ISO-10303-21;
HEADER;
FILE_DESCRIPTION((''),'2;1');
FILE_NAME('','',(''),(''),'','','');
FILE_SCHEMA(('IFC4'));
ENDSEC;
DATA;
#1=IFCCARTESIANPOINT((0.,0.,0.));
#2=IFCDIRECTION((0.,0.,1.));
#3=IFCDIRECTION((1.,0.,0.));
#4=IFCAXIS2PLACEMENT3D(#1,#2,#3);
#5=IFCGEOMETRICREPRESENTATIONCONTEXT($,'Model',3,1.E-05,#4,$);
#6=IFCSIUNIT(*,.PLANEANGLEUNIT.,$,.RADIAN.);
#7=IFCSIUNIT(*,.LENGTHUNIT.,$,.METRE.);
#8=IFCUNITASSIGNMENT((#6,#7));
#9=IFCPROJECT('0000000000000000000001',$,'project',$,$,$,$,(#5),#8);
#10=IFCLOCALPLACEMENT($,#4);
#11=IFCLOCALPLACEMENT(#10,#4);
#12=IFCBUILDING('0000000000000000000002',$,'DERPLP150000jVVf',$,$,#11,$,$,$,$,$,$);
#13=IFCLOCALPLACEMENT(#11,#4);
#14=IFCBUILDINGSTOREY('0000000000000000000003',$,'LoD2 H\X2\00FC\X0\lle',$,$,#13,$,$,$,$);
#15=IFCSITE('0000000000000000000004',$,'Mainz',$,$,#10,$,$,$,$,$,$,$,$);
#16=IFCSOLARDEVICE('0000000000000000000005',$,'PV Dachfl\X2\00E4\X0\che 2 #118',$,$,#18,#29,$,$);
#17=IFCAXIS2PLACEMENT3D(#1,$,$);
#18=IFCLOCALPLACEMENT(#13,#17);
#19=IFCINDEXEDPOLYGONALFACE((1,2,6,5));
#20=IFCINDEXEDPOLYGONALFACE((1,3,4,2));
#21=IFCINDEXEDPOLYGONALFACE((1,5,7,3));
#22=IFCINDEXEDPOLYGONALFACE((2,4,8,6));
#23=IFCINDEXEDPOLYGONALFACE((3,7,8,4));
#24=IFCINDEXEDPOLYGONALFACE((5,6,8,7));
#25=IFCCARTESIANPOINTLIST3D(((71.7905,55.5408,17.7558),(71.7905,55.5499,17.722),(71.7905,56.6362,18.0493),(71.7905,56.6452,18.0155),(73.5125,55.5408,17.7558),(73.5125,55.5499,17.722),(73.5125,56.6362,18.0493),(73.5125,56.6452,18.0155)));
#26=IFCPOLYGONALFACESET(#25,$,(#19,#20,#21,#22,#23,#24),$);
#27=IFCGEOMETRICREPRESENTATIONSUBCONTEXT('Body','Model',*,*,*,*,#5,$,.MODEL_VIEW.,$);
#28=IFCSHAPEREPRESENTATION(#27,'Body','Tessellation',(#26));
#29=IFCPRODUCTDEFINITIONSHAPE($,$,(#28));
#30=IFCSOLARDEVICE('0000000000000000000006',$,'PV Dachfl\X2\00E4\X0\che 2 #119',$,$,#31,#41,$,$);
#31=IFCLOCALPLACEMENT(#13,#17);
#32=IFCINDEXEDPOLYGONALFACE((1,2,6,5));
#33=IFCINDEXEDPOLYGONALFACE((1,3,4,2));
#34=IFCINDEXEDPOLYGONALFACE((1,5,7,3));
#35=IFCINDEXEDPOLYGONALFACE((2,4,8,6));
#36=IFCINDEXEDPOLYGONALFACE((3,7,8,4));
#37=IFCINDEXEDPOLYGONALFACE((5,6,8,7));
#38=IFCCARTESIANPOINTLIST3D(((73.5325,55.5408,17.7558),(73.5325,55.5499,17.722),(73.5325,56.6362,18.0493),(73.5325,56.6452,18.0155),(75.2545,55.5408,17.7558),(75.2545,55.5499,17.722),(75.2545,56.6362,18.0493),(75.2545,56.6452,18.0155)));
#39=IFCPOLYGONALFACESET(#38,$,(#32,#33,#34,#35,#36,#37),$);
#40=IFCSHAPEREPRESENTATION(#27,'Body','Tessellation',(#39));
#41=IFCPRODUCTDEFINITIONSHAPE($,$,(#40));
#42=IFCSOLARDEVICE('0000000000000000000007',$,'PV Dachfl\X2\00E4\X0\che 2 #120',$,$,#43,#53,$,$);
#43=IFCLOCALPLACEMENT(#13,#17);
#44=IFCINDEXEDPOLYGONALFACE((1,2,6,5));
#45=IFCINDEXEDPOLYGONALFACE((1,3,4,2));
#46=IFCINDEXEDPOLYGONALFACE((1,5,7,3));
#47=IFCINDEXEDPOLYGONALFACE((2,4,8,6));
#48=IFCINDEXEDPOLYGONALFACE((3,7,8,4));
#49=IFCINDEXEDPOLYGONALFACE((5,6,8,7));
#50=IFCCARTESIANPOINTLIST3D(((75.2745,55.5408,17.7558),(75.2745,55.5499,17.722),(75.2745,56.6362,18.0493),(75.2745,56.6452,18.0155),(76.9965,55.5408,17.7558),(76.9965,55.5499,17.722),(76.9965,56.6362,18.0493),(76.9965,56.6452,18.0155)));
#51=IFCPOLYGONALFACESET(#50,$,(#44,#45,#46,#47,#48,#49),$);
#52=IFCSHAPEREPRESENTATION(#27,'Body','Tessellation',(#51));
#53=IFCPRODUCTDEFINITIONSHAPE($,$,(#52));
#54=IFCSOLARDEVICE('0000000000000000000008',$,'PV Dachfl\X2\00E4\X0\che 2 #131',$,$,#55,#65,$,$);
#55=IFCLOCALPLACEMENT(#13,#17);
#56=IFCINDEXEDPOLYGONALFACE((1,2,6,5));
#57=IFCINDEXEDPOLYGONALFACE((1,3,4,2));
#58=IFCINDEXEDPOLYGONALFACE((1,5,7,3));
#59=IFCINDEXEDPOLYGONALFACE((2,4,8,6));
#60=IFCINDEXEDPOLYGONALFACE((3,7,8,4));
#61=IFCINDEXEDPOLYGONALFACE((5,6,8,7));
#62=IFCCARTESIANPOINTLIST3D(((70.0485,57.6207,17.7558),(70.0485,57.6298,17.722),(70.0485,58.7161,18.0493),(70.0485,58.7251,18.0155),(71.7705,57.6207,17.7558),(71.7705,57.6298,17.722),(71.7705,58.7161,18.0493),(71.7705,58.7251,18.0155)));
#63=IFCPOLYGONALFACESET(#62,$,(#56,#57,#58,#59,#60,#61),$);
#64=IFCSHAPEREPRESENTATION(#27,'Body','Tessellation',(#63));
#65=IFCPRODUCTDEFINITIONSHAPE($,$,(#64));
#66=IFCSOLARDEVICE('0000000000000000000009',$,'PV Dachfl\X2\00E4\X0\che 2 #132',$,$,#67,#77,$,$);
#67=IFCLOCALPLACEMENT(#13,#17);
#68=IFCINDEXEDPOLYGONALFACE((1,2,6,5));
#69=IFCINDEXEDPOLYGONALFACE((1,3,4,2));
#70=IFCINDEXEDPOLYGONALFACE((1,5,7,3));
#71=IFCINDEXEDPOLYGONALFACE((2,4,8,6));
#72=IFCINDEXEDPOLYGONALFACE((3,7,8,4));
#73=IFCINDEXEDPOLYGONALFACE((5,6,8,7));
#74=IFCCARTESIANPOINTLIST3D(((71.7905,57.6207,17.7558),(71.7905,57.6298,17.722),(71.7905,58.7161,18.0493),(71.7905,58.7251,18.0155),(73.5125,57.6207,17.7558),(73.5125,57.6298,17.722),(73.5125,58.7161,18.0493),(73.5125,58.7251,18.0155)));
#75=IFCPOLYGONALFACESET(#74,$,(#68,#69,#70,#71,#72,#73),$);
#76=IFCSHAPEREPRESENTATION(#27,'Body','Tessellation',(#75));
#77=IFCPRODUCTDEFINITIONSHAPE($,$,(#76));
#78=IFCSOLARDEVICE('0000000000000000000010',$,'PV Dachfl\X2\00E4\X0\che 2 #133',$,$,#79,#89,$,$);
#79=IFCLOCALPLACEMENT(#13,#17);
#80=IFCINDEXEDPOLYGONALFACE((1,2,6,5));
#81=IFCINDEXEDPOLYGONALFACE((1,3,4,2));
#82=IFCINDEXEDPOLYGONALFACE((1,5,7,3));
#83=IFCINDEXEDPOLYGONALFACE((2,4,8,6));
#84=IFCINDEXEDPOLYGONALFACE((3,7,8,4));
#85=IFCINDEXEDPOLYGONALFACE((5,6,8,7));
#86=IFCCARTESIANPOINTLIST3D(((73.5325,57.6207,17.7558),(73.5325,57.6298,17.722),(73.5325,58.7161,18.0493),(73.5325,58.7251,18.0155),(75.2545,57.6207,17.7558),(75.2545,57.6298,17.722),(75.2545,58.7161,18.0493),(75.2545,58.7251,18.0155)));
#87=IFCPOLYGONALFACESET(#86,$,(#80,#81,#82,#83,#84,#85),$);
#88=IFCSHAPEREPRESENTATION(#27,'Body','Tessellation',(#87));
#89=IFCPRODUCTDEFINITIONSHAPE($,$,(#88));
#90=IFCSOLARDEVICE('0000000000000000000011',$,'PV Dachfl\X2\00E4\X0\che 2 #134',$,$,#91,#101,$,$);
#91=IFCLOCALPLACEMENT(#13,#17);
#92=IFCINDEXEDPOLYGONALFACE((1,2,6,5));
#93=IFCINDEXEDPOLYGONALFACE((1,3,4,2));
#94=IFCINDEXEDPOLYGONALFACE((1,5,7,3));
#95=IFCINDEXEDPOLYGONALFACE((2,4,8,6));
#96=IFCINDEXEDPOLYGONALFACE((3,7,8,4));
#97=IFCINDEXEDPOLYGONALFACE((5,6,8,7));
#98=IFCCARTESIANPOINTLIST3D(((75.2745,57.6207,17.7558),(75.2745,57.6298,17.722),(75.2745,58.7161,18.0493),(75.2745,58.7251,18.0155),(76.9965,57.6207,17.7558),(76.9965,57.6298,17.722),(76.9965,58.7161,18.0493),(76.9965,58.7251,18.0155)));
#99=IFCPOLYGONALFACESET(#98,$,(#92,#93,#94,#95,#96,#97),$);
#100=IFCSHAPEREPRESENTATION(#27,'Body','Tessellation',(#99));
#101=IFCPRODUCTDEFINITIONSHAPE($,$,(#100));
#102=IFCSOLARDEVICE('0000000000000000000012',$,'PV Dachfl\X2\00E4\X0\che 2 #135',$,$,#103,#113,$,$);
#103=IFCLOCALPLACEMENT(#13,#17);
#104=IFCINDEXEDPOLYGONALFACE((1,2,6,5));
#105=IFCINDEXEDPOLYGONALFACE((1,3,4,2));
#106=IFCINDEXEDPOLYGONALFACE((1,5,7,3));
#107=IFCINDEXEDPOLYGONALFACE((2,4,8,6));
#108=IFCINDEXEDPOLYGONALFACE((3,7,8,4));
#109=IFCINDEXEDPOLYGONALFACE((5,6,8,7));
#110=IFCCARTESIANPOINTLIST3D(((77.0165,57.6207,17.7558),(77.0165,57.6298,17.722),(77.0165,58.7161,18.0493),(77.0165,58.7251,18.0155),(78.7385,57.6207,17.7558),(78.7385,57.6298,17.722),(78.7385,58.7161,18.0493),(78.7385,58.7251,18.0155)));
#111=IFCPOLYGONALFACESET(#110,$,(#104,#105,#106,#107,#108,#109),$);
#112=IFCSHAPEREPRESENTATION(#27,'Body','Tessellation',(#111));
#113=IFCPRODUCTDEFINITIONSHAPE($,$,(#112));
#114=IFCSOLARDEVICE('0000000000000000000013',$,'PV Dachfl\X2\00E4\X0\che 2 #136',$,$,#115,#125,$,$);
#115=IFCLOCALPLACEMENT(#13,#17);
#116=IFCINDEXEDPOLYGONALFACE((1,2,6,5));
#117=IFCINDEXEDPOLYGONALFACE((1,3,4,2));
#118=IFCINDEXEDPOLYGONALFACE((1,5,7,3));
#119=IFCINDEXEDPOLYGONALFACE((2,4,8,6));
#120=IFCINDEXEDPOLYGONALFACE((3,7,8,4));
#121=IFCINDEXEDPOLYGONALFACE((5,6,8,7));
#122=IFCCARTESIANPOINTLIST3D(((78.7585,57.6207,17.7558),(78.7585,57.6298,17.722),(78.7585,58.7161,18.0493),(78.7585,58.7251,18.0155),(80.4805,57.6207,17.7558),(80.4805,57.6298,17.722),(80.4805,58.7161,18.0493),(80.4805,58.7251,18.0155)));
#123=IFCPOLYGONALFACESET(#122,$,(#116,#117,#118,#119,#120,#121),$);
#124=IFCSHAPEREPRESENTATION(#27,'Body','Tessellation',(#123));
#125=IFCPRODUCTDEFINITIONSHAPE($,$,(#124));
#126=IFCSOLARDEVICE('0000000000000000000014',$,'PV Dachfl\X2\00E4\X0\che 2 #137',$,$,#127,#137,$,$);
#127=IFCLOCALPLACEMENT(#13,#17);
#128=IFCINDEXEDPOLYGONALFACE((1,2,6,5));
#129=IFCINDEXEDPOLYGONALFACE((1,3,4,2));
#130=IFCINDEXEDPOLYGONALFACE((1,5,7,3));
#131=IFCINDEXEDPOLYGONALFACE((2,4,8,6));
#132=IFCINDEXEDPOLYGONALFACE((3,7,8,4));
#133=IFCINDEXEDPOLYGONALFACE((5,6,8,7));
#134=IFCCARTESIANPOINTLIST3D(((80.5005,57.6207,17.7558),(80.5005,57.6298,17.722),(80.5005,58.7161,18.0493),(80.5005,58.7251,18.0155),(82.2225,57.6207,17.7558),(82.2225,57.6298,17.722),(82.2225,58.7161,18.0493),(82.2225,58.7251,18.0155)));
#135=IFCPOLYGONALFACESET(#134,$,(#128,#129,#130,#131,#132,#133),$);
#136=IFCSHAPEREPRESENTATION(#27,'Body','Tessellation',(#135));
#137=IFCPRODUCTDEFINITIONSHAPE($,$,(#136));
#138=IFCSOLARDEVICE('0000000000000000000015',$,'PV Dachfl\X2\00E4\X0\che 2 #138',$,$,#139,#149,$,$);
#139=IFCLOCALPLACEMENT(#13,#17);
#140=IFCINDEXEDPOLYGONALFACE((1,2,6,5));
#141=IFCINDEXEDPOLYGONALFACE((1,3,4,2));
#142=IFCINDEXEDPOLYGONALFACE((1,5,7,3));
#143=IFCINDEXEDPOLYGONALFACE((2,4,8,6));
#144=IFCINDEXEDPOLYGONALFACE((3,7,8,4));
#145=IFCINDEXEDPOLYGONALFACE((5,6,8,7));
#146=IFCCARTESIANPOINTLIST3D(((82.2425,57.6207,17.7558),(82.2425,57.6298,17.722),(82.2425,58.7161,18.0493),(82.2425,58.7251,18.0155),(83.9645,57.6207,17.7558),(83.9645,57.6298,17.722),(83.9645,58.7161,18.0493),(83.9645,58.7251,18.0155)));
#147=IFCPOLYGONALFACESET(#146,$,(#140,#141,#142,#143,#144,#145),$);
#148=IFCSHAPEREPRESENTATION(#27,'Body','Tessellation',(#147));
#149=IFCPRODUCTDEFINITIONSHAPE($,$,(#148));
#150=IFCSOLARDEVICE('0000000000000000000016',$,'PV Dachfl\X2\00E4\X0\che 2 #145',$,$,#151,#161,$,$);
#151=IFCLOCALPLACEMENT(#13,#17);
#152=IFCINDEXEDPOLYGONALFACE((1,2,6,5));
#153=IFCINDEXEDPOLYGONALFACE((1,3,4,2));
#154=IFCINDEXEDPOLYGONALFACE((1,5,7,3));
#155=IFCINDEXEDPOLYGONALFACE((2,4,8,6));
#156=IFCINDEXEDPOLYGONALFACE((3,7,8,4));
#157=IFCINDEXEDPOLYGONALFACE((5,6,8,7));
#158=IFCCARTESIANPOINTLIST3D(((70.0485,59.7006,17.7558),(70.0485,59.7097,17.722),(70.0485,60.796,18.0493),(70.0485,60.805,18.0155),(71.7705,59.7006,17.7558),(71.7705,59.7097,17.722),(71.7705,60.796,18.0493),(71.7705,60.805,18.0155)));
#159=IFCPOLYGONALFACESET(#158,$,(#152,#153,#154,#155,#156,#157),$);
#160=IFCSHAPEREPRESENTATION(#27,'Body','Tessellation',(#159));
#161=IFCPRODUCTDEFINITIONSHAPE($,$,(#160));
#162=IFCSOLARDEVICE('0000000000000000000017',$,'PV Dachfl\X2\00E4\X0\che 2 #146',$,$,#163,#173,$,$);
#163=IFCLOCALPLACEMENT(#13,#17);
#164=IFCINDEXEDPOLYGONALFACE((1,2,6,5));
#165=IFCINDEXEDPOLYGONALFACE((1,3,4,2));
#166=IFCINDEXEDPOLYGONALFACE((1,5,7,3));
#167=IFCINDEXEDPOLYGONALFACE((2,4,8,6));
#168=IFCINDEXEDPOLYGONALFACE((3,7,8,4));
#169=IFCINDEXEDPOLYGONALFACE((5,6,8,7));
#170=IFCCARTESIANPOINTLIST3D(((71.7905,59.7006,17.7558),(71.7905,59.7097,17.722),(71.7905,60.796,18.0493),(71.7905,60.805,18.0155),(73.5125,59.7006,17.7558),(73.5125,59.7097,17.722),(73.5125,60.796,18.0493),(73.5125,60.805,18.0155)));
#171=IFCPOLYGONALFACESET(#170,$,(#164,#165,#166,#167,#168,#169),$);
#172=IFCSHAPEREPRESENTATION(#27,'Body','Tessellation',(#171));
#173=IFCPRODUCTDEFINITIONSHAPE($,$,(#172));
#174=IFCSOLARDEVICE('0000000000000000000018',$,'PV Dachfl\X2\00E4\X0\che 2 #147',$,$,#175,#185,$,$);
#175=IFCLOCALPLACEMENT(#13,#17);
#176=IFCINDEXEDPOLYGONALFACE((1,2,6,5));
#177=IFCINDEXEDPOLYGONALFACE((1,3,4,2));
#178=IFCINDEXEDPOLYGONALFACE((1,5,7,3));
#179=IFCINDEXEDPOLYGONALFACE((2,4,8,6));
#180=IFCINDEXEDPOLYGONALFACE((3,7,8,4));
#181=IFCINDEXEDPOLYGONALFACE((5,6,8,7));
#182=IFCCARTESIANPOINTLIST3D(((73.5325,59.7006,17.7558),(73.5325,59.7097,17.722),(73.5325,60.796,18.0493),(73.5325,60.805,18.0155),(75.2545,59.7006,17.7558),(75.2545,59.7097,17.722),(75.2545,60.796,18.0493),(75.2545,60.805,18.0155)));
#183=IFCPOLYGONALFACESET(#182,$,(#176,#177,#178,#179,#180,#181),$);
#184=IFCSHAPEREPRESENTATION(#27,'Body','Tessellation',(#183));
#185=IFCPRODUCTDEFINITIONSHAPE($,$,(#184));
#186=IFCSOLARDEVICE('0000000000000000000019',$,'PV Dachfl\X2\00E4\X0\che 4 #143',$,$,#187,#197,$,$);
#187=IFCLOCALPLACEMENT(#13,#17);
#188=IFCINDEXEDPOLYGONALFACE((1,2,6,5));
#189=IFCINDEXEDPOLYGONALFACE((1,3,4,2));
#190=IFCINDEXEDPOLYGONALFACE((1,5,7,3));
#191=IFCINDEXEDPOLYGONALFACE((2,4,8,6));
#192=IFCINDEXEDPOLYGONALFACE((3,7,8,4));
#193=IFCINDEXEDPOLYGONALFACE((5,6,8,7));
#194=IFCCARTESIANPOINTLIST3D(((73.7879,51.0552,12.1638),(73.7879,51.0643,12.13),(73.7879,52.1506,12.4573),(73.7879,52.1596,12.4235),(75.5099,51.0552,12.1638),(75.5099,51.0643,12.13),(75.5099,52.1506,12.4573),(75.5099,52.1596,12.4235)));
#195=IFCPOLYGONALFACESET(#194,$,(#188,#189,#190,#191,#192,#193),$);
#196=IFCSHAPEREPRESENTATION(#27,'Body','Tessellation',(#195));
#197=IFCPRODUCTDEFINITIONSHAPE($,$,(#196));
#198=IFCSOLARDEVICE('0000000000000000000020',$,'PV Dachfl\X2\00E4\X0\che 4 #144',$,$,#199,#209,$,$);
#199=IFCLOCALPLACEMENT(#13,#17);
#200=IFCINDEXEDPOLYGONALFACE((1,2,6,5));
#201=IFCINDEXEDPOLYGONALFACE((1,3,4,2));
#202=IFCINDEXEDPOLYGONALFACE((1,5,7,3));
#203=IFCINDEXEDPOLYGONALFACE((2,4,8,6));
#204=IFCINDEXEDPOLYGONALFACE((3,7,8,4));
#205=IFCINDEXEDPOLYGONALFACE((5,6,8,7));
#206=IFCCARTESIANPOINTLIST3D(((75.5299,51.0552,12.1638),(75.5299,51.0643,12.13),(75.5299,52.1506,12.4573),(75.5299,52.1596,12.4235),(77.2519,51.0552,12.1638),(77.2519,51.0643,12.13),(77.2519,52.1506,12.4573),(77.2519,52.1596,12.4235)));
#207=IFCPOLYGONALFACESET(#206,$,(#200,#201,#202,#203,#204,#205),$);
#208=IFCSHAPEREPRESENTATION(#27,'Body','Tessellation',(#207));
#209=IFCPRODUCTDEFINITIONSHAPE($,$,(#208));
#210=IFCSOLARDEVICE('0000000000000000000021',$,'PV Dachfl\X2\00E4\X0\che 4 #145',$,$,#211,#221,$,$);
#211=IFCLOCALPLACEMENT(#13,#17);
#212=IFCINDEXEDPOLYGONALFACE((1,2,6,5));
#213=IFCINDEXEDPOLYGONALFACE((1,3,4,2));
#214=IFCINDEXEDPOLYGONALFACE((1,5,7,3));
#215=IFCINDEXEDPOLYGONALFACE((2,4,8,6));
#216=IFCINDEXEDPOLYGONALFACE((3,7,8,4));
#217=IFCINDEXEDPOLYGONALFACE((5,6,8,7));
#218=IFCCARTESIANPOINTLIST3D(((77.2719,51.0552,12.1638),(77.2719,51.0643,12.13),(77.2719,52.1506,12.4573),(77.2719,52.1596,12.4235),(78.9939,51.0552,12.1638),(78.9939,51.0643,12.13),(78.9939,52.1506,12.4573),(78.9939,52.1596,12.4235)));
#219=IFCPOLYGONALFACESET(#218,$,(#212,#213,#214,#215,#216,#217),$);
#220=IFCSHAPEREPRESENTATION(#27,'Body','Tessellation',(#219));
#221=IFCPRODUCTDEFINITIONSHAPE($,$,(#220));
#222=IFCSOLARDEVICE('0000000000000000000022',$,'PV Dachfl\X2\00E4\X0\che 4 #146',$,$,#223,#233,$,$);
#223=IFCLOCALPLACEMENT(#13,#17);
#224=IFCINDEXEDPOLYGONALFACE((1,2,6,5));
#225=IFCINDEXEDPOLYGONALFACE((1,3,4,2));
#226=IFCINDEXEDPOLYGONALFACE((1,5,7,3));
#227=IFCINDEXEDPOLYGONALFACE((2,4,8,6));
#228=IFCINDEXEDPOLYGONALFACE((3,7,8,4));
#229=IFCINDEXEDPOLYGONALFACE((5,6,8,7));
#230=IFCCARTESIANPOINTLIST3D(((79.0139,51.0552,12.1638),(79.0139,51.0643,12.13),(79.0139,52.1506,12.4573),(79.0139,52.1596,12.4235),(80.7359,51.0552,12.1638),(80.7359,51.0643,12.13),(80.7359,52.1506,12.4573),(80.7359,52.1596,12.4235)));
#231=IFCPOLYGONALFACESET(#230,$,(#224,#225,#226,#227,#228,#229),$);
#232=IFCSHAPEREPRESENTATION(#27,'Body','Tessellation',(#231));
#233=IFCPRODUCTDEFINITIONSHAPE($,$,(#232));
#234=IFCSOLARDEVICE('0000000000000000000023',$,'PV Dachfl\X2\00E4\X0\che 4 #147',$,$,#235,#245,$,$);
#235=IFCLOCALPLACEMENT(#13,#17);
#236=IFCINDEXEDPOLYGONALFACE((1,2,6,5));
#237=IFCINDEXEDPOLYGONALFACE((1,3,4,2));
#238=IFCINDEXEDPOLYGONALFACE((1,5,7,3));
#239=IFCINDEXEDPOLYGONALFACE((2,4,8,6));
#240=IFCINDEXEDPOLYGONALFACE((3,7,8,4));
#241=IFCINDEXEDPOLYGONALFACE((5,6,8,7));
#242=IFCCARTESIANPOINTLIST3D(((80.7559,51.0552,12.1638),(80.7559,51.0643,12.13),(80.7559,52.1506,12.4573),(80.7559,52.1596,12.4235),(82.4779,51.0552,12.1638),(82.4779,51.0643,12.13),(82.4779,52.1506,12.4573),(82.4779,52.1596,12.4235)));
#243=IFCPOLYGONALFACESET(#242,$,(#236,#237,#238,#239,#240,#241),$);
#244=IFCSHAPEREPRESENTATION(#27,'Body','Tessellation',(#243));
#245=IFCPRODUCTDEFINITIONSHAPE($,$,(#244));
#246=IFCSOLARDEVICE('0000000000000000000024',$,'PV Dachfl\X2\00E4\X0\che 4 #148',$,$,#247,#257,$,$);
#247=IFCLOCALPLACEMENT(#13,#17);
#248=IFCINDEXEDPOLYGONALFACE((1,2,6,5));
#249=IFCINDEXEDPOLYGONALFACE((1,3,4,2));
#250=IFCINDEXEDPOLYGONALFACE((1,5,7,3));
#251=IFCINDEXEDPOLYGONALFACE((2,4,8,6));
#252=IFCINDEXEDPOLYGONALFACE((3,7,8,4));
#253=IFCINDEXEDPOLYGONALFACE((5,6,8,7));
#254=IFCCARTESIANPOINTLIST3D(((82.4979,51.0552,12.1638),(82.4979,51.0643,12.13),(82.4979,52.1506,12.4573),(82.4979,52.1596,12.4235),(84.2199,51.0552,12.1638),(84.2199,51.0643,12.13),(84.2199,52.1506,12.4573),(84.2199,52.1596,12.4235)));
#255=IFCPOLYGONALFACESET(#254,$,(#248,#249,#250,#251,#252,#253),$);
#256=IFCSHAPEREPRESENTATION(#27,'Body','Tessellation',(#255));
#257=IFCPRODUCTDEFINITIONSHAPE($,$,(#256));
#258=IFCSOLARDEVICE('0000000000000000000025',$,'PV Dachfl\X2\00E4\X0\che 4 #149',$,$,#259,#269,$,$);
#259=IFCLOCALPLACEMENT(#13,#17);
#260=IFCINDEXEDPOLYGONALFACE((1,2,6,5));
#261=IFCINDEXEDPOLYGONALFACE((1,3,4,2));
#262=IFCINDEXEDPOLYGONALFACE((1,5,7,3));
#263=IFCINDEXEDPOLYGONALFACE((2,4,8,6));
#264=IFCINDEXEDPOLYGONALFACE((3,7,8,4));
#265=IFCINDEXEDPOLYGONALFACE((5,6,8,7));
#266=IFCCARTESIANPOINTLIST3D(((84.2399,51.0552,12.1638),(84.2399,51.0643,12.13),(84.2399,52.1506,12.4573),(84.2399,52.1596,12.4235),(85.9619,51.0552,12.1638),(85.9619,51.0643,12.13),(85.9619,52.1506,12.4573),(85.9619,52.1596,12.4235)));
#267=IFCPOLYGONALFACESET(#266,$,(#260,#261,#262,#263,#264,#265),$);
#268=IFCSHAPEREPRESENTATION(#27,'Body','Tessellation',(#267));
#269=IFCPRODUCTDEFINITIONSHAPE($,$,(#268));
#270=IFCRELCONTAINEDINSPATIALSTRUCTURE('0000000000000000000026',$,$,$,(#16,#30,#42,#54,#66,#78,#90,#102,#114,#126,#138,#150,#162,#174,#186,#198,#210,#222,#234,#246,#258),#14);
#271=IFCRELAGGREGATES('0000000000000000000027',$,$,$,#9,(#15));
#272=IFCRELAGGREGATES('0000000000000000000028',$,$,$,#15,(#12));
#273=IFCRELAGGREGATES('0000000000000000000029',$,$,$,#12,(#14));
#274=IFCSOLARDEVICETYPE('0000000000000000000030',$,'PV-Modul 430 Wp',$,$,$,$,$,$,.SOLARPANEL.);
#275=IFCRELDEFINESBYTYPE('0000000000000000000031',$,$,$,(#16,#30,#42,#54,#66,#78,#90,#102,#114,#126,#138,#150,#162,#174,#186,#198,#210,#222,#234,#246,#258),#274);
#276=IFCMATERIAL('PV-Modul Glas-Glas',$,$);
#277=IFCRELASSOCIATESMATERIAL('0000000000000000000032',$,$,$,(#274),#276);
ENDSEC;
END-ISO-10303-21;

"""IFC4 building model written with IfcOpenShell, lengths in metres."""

from ifc_helpers import new_model, si_unit, frame, frame_2d, origin, origin_with_axes, place, context, subcontext, project, spatial, rectangle, extrude, source, transform, mapped, material, type_object, type_shapes, element, save


model = new_model("IFC4")

# Units and contexts
model_context = context("Model", 3, precision=1e-05, world=origin_with_axes())
body_context = subcontext(model_context, "Body", "Model", "MODEL_VIEW")
ifc_project = project(units=[si_unit("PLANEANGLEUNIT", "RADIAN"), si_unit("LENGTHUNIT", "METRE")], contexts=[model_context])

# Site, building, storey
site_placement = place(None, origin_with_axes())
site = spatial("IfcSite", under=ifc_project, at=site_placement, Name="Mainz")
building_placement = place(site_placement, origin_with_axes())
building = spatial("IfcBuilding", under=site, at=building_placement, Name="DERPLP150000jVVf")
storey_placement = place(building_placement, origin_with_axes())
storey = spatial("IfcBuildingStorey", under=building, at=storey_placement, Name="LoD2 Hülle")

# Solar devices
ifc_material = material(Name="PV-Modul Glas-Glas")
solar_device_type = type_object("IfcSolarDeviceType", Name="PV-Modul 430 Wp", PredefinedType="SOLARPANEL", material=ifc_material)
shared_shape = source(origin_with_axes(), body_context, "Body", "SweptSolid", [
    extrude(rectangle(XDim=1.722, YDim=1.134, at=frame_2d((0.861, 0.567))), origin(), (0.0, 0.0, 1.0), 0.035),
])
type_shapes(solar_device_type, [shared_shape])
for number, where, z_axis, x_axis, name in (
    (1, (71.7905, 55.5499, 17.722), (0.0, -0.258819, 0.965926), (1.0, 0.0, 0.0), "PV Dachfläche 2 #118"),
    (2, (73.5325, 55.5499, 17.722), (0.0, -0.258819, 0.965926), (1.0, 0.0, 0.0), "PV Dachfläche 2 #119"),
    (3, (75.2745, 55.5499, 17.722), (0.0, -0.258819, 0.965926), (1.0, 0.0, 0.0), "PV Dachfläche 2 #120"),
    (4, (70.0485, 57.6298, 17.722), (0.0, -0.258819, 0.965926), (1.0, 0.0, 0.0), "PV Dachfläche 2 #131"),
    (5, (71.7905, 57.6298, 17.722), (0.0, -0.258819, 0.965926), (1.0, 0.0, 0.0), "PV Dachfläche 2 #132"),
    (6, (73.5325, 57.6298, 17.722), (0.0, -0.258819, 0.965926), (1.0, 0.0, 0.0), "PV Dachfläche 2 #133"),
    (7, (75.2745, 57.6298, 17.722), (0.0, -0.258819, 0.965926), (1.0, 0.0, 0.0), "PV Dachfläche 2 #134"),
    (8, (77.0165, 57.6298, 17.722), (0.0, -0.258819, 0.965926), (1.0, 0.0, 0.0), "PV Dachfläche 2 #135"),
    (9, (78.7585, 57.6298, 17.722), (0.0, -0.258819, 0.965926), (1.0, 0.0, 0.0), "PV Dachfläche 2 #136"),
    (10, (80.5005, 57.6298, 17.722), (0.0, -0.258819, 0.965926), (1.0, 0.0, 0.0), "PV Dachfläche 2 #137"),
    (11, (82.2425, 57.6298, 17.722), (0.0, -0.258819, 0.965926), (1.0, 0.0, 0.0), "PV Dachfläche 2 #138"),
    (12, (70.0485, 59.7097, 17.722), (0.0, -0.258819, 0.965926), (1.0, 0.0, 0.0), "PV Dachfläche 2 #145"),
    (13, (71.7905, 59.7097, 17.722), (0.0, -0.258819, 0.965926), (1.0, 0.0, 0.0), "PV Dachfläche 2 #146"),
    (14, (73.5325, 59.7097, 17.722), (0.0, -0.258819, 0.965926), (1.0, 0.0, 0.0), "PV Dachfläche 2 #147"),
    (15, (73.7879, 51.0643, 12.13), (0.0, -0.258819, 0.965926), (1.0, 0.0, 0.0), "PV Dachfläche 4 #143"),
    (16, (75.5299, 51.0643, 12.13), (0.0, -0.258819, 0.965926), (1.0, 0.0, 0.0), "PV Dachfläche 4 #144"),
    (17, (77.2719, 51.0643, 12.13), (0.0, -0.258819, 0.965926), (1.0, 0.0, 0.0), "PV Dachfläche 4 #145"),
    (18, (79.0139, 51.0643, 12.13), (0.0, -0.258819, 0.965926), (1.0, 0.0, 0.0), "PV Dachfläche 4 #146"),
    (19, (80.7559, 51.0643, 12.13), (0.0, -0.258819, 0.965926), (1.0, 0.0, 0.0), "PV Dachfläche 4 #147"),
    (20, (82.4979, 51.0643, 12.13), (0.0, -0.258819, 0.965926), (1.0, 0.0, 0.0), "PV Dachfläche 4 #148"),
    (21, (84.2399, 51.0643, 12.13), (0.0, -0.258819, 0.965926), (1.0, 0.0, 0.0), "PV Dachfläche 4 #149"),
):
    element("IfcSolarDevice", number, at=place(storey_placement, frame(where, z_axis=z_axis, x_axis=x_axis)), inside=storey, type_object=solar_device_type, Name=name, context=body_context, shape_type="MappedRepresentation", body=[
        mapped(shared_shape, transform((0.0, 0.0, 0.0), x_axis=(1.0, 0.0, 0.0), y_axis=(0.0, 1.0, 0.0), z_axis=(0.0, 0.0, 1.0), scale=1.0)),
    ])

save(model, "model.ifc")
